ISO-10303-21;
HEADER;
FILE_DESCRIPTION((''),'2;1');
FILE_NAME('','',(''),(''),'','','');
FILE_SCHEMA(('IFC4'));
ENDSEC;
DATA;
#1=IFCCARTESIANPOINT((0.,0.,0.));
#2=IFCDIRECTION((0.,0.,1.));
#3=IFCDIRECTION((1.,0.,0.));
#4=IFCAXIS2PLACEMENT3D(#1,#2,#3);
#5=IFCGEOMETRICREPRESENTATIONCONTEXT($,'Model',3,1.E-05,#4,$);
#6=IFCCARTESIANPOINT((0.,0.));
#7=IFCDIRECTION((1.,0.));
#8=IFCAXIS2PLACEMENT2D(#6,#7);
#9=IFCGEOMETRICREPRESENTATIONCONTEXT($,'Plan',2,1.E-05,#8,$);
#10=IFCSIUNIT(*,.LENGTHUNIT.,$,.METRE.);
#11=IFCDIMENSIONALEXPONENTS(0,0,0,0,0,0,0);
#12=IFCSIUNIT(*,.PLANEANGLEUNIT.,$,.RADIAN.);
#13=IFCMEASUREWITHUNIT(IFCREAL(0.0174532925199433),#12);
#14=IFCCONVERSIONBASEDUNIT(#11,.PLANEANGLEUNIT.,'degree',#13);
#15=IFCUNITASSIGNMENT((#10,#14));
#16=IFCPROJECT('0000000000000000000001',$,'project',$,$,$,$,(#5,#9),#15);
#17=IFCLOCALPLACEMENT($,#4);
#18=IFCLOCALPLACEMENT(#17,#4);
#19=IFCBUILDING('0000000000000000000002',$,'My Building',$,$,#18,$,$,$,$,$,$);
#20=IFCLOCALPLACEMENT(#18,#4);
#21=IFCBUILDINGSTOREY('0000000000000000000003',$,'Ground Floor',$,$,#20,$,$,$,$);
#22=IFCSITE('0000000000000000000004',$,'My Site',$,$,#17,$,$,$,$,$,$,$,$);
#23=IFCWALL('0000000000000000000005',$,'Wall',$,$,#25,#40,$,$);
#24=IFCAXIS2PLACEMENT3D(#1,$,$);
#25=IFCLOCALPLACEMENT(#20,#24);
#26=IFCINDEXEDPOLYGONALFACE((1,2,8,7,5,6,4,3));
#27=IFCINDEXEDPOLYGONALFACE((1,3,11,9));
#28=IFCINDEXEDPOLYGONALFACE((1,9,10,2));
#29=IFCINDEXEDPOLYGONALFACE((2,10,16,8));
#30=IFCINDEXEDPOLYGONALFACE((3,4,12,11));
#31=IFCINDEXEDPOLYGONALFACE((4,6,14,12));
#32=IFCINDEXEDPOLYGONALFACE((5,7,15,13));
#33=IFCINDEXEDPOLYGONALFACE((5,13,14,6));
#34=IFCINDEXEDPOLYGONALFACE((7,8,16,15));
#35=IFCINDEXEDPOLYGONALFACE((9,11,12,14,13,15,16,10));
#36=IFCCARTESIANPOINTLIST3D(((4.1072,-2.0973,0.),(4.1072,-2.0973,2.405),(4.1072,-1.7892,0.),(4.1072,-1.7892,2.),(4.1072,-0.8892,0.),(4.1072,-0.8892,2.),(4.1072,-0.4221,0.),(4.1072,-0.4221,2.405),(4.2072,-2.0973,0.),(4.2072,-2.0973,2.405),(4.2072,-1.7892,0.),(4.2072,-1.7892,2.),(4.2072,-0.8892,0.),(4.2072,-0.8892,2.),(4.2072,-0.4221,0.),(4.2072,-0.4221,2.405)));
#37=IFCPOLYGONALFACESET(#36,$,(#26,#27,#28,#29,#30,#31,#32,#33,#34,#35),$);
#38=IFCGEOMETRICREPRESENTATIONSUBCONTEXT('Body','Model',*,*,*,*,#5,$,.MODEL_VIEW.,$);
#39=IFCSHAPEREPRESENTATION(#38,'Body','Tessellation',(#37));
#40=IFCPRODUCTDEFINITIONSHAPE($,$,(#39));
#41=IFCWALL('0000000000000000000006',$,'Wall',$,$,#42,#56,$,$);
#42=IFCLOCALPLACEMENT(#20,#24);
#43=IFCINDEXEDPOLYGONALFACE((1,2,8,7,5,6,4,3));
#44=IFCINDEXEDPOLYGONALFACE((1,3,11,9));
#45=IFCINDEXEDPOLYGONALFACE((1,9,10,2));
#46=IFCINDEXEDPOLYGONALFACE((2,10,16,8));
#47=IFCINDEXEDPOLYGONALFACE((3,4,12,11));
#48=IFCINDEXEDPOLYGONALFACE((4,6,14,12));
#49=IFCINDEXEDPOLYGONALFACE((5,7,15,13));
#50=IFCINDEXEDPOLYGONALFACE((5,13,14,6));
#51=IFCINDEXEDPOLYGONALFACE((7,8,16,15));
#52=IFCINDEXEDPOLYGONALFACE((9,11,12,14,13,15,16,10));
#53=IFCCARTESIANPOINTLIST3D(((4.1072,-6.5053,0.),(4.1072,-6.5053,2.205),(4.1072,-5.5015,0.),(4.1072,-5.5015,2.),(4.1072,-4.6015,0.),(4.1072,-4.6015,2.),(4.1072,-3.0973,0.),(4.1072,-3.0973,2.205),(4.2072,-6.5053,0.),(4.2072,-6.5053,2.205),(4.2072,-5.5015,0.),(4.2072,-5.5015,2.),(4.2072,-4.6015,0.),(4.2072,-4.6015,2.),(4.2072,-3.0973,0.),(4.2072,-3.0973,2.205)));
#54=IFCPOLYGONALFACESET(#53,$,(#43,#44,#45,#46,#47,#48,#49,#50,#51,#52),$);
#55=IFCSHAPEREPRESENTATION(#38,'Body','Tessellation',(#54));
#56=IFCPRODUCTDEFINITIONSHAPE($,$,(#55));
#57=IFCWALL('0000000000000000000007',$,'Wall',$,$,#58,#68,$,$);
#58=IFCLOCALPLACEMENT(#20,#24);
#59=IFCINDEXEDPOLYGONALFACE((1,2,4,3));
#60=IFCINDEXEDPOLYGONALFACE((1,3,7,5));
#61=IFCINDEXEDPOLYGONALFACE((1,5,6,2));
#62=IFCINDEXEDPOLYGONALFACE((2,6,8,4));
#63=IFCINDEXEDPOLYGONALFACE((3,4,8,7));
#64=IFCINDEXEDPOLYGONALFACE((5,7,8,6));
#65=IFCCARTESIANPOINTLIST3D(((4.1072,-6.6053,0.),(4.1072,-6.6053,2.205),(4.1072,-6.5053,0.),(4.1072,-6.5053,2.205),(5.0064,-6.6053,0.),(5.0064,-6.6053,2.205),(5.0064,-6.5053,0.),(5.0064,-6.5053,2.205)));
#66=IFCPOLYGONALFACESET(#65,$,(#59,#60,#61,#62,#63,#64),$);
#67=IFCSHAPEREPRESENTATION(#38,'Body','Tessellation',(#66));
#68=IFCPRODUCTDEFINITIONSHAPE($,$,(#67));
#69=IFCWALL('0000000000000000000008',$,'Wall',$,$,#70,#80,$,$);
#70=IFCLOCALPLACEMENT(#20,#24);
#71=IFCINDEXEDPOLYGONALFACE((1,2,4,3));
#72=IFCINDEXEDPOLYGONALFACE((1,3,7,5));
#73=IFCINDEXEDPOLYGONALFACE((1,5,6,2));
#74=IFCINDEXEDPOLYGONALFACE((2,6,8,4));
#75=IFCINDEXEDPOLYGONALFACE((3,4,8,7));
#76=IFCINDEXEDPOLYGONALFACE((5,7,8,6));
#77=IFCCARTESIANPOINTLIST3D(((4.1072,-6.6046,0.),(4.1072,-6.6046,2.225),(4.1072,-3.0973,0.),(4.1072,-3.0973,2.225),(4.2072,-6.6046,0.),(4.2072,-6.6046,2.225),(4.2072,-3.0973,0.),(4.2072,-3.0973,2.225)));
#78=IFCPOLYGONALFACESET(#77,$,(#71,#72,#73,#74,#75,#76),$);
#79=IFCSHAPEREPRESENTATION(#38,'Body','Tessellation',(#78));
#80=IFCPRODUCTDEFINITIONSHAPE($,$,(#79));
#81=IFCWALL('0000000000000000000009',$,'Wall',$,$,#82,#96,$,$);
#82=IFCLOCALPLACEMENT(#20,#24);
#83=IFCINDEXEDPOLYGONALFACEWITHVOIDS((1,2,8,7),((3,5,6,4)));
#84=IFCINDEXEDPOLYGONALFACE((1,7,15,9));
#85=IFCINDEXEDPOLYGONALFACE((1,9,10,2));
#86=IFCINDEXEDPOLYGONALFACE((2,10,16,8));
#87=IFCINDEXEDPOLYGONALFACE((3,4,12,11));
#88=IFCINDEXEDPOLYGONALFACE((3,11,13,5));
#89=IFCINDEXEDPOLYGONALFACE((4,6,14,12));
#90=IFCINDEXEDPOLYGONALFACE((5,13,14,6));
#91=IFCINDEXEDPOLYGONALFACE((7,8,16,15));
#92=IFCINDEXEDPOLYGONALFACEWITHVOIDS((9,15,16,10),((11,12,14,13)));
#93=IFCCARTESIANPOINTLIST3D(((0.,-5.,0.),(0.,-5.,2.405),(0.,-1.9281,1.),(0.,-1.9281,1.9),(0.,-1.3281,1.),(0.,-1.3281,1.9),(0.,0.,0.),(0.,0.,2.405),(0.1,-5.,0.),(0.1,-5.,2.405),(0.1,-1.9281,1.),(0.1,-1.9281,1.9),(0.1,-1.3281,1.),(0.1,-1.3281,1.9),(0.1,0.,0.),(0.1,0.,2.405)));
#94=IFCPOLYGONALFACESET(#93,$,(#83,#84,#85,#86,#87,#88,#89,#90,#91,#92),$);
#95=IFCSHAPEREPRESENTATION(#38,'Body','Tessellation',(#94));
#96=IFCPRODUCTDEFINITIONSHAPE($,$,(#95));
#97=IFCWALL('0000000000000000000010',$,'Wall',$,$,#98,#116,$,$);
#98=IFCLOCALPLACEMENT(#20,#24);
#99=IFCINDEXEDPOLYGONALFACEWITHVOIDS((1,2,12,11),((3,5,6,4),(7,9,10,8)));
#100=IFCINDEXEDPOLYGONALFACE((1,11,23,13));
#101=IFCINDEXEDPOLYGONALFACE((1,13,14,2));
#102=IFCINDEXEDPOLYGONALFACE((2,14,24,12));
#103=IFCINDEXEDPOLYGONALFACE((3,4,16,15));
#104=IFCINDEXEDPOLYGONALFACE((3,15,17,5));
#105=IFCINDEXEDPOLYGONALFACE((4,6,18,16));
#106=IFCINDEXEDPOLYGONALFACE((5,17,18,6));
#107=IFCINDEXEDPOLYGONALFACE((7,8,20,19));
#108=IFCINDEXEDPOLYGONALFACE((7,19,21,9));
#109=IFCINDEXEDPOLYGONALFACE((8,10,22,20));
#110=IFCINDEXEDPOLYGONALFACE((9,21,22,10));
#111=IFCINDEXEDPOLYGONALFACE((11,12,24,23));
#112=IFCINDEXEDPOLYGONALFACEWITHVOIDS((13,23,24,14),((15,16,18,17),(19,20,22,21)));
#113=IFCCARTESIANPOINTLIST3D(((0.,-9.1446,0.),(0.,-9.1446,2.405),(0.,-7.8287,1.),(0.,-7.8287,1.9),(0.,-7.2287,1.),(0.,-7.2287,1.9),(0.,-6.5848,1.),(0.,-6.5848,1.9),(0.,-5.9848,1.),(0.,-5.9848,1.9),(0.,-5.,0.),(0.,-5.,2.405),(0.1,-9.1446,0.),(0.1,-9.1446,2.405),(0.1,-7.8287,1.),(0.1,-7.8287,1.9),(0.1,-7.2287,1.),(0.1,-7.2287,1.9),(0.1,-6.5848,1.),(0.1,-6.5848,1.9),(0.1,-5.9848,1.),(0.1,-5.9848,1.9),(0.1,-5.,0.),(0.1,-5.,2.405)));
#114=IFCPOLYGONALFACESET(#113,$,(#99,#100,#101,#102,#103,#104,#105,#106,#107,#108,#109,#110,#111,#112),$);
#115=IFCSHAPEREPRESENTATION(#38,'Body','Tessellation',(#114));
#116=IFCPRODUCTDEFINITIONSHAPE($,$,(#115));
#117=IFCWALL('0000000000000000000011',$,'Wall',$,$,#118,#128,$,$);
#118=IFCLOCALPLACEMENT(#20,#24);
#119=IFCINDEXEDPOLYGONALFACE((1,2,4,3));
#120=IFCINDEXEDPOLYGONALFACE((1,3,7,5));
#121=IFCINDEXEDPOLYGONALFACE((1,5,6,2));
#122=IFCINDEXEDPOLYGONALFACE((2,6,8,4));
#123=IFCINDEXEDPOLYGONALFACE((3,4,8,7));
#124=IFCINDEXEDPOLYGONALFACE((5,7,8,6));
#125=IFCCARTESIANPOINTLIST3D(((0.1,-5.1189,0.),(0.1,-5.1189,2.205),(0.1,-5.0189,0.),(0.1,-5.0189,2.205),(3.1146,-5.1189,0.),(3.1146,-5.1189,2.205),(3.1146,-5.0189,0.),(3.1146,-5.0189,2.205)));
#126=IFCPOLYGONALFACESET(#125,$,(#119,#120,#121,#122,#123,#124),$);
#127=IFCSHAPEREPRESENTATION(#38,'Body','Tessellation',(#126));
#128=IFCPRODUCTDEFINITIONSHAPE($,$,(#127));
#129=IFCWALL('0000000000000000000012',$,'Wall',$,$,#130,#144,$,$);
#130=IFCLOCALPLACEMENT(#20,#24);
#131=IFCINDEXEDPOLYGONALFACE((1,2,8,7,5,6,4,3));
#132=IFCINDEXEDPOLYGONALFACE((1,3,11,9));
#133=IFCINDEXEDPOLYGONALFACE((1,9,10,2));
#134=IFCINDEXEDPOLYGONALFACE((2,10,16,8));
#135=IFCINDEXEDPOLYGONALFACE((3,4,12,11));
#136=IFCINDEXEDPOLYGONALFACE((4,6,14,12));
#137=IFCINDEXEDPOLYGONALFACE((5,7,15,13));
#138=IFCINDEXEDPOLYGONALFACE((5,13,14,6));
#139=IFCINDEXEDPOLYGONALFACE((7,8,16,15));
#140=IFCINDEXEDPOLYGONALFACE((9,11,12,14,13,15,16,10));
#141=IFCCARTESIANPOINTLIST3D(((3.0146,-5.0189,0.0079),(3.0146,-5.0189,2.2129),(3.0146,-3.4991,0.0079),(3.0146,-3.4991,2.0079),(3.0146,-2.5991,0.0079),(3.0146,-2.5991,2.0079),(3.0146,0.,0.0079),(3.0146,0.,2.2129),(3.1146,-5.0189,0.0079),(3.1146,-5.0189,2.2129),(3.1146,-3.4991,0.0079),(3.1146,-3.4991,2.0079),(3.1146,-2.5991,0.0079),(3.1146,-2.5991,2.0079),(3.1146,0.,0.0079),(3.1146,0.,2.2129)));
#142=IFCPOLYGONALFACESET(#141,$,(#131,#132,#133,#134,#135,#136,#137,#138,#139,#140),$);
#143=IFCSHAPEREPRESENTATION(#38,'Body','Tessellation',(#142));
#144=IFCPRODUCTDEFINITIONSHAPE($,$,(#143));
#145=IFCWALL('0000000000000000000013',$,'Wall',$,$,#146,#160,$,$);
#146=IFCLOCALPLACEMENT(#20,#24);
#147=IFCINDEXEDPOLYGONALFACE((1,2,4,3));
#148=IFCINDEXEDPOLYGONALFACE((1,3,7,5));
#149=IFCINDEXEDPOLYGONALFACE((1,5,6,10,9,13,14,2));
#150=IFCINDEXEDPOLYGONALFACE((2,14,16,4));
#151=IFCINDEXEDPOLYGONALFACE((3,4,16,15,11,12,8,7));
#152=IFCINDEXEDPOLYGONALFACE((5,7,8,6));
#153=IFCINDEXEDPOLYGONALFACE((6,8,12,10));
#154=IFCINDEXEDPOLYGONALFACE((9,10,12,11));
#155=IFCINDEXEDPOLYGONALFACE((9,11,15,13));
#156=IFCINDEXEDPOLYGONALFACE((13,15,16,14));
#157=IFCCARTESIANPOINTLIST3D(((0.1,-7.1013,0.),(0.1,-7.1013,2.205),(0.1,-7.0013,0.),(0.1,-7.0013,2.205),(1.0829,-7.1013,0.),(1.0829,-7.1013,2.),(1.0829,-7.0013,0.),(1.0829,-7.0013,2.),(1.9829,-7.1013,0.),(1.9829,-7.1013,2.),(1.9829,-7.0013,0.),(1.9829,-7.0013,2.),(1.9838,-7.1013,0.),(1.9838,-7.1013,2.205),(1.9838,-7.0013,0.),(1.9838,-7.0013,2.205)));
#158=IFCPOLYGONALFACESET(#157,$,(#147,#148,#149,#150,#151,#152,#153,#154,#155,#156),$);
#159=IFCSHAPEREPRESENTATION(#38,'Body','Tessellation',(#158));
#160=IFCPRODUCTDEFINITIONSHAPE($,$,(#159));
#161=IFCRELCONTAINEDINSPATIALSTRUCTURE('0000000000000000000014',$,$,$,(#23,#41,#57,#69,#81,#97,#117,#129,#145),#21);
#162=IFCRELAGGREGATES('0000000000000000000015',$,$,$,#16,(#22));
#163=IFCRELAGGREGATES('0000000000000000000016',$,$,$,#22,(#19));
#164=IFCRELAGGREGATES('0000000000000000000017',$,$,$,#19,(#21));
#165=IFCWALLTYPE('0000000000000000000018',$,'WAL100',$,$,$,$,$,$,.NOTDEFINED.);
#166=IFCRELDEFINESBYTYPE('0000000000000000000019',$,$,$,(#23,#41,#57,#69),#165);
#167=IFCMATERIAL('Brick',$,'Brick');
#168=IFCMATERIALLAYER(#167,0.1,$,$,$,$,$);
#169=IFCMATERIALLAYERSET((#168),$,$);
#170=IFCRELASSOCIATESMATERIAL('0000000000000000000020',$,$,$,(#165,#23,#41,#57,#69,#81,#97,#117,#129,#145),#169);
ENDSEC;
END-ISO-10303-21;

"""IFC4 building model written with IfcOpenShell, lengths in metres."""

from ifc_helpers import new_model, entity, si_unit, converted_unit, frame, origin_with_axes, origin_2d_with_axis, place, context, subcontext, project, spatial, line, indexed_curve, outline, extrude, source, transform, mapped, material, layer, layer_set, layer_usage, type_object, element, save


model = new_model("IFC4")

# Units and contexts
model_context = context("Model", 3, precision=1e-05, world=origin_with_axes())
plan_context = context("Plan", 2, precision=1e-05, world=origin_2d_with_axis())
body_context = subcontext(model_context, "Body", "Model", "MODEL_VIEW")
ifc_project = project(units=[si_unit("LENGTHUNIT", "METRE"), converted_unit("PLANEANGLEUNIT", "degree", entity("IfcReal", 0.0174532925199433), si_unit("PLANEANGLEUNIT", "RADIAN"), dimensions=[0, 0, 0, 0, 0, 0, 0])], contexts=[model_context, plan_context])

# Site, building, storey
site_placement = place(None, origin_with_axes())
site = spatial("IfcSite", under=ifc_project, at=site_placement, Name="My Site")
building_placement = place(site_placement, origin_with_axes())
building = spatial("IfcBuilding", under=site, at=building_placement, Name="My Building")
storey_placement = place(building_placement, origin_with_axes())
storey = spatial("IfcBuildingStorey", under=building, at=storey_placement, Name="Ground Floor")

# Shared definitions
ifc_material_1 = material(Name="Brick", Category="Brick")
ifc_layer_1 = layer(ifc_material_1, 0.1)
ifc_layer_set_1 = layer_set([ifc_layer_1])
wall_type = type_object("IfcWallType", Name="WAL100", PredefinedType="NOTDEFINED", material=ifc_layer_set_1)

# Shared definitions
shared_shape_1 = source(origin_with_axes(), body_context, "Body", "SweptSolid", [
    extrude(outline(indexed_curve([(0.0, 0.0), (0.9, 0.0), (0.9, 2.0), (0.0, 2.0)], segments=[line(1, 2, 3, 4, 1)])), frame((0.0, -0.1, 0.0), z_axis=(0.0, -1.0, 0.0), x_axis=(1.0, 0.0, 0.0)), (0.0, 0.0, -1.0), 0.3),
])

# Walls, openings
ifc_layer_usage_1 = layer_usage(ifc_layer_set_1, "AXIS2", "POSITIVE", 0.0)
wall_1_placement = place(storey_placement, frame((4.1072, -0.4221, 0.0), z_axis=(0.0, 0.0, 1.0), x_axis=(-0.000001, -1.0, 0.0)))
wall_1 = element("IfcWall", 1, at=wall_1_placement, inside=storey, type_object=wall_type, material=ifc_layer_usage_1, Name="Wall", context=body_context, shape_type="SweptSolid", body=[
    extrude(outline(indexed_curve([(0.0, 0.0), (0.0, 0.1), (1.6752, 0.1), (1.6752, 0.0), (0.0, 0.0)], self_intersect=False)), origin_with_axes(), (0.0, 0.0, 1.0), 2.405),
])
opening_1_placement = place(wall_1_placement, frame((0.4671, 0.0, 0.0), z_axis=(0.0, 0.0, 1.0), x_axis=(1.0, 0.0, 0.0)))
element("IfcOpeningElement", 2, at=opening_1_placement, cuts=wall_1, PredefinedType="OPENING", context=body_context, shape_type="MappedRepresentation", body=[
    mapped(shared_shape_1, transform((0.0, 0.0, 0.0), x_axis=(1.0, 0.0, 0.0), y_axis=(0.0, 1.0, 0.0), z_axis=(0.0, 0.0, 1.0), scale=1.0)),
])
ifc_layer_usage_2 = layer_usage(ifc_layer_set_1, "AXIS2", "POSITIVE", 0.0)
wall_2_placement = place(storey_placement, frame((4.1072, -3.0973, 0.0), z_axis=(0.0, 0.0, 1.0), x_axis=(-0.000001, -1.0, 0.0)))
wall_2 = element("IfcWall", 3, at=wall_2_placement, inside=storey, type_object=wall_type, material=ifc_layer_usage_2, Name="Wall", context=body_context, shape_type="SweptSolid", body=[
    extrude(outline(indexed_curve([(0.0, 0.0), (0.0, 0.1), (3.408, 0.1), (3.408, 0.0), (0.0, 0.0)], self_intersect=False)), origin_with_axes(), (0.0, 0.0, 1.0), 2.205),
])
opening_2_placement = place(wall_2_placement, frame((2.4042, 0.1, 0.0), z_axis=(0.0, 0.0, 1.0), x_axis=(-1.0, 0.0, 0.0)))
element("IfcOpeningElement", 4, at=opening_2_placement, cuts=wall_2, PredefinedType="OPENING", context=body_context, shape_type="MappedRepresentation", body=[
    mapped(shared_shape_1, transform((0.0, 0.0, 0.0), x_axis=(1.0, 0.0, 0.0), y_axis=(0.0, 1.0, 0.0), z_axis=(0.0, 0.0, 1.0), scale=1.0)),
])

# Walls
ifc_layer_usage_3 = layer_usage(ifc_layer_set_1, "AXIS2", "POSITIVE", 0.0)
wall_3_placement = place(storey_placement, frame((5.0064, -6.5053, 0.0), z_axis=(0.0, 0.0, 1.0), x_axis=(-1.0, 0.000001, 0.0)))
element("IfcWall", 5, at=wall_3_placement, inside=storey, type_object=wall_type, material=ifc_layer_usage_3, Name="Wall", context=body_context, shape_type="SweptSolid", body=[
    extrude(outline(indexed_curve([(0.0, 0.0), (0.0, 0.1), (0.8992, 0.1), (0.8992, 0.0), (0.0, 0.0)], self_intersect=False)), origin_with_axes(), (0.0, 0.0, 1.0), 2.205),
])
ifc_layer_usage_4 = layer_usage(ifc_layer_set_1, "AXIS2", "POSITIVE", 0.0)
wall_4_placement = place(storey_placement, frame((4.1072, -3.0973, 0.0), z_axis=(0.0, 0.0, 1.0), x_axis=(-0.000001, -1.0, 0.0)))
element("IfcWall", 6, at=wall_4_placement, inside=storey, type_object=wall_type, material=ifc_layer_usage_4, Name="Wall", context=body_context, shape_type="SweptSolid", body=[
    extrude(outline(indexed_curve([(0.0, 0.0), (0.0, 0.1), (3.5073, 0.1), (3.5073, 0.0), (0.0, 0.0)], self_intersect=False)), origin_with_axes(), (0.0, 0.0, 1.0), 2.225),
])

# Wall, opening
ifc_layer_usage_5 = layer_usage(ifc_layer_set_1, "AXIS2", "POSITIVE", 0.0)
wall_5_placement = place(storey_placement, frame((0.0, 0.0, 0.0), z_axis=(0.0, 0.0, 1.0), x_axis=(-0.000001, -1.0, 0.0)))
wall_5 = element("IfcWall", 7, at=wall_5_placement, inside=storey, material=ifc_layer_usage_5, Name="Wall", context=body_context, shape_type="SweptSolid", body=[
    extrude(outline(indexed_curve([(0.0, 0.0), (0.0, 0.1), (5.0, 0.1), (5.0, 0.0), (0.0, 0.0)], self_intersect=False)), origin_with_axes(), (0.0, 0.0, 1.0), 2.405),
])
shared_shape_2 = source(origin_with_axes(), body_context, "Body", "SweptSolid", [
    extrude(outline(indexed_curve([(0.0, 0.0), (0.6, 0.0), (0.6, 0.9), (0.0, 0.9)], segments=[line(1, 2, 3, 4, 1)])), frame((0.0, -0.1, 0.0), z_axis=(0.0, -1.0, 0.0), x_axis=(1.0, 0.0, 0.0)), (0.0, 0.0, -1.0), 0.3),
])
opening_3_placement = place(wall_5_placement, frame((1.3281, 0.0, 1.0), z_axis=(0.0, 0.0, 1.0), x_axis=(1.0, 0.0, 0.0)))
element("IfcOpeningElement", 8, at=opening_3_placement, cuts=wall_5, PredefinedType="OPENING", context=body_context, shape_type="MappedRepresentation", body=[
    mapped(shared_shape_2, transform((0.0, 0.0, 0.0), x_axis=(1.0, 0.0, 0.0), y_axis=(0.0, 1.0, 0.0), z_axis=(0.0, 0.0, 1.0), scale=1.0)),
])

# Wall, openings
ifc_layer_usage_6 = layer_usage(ifc_layer_set_1, "AXIS2", "POSITIVE", 0.0)
wall_6_placement = place(storey_placement, frame((0.0, -5.0, 0.0), z_axis=(0.0, 0.0, 1.0), x_axis=(-0.000001, -1.0, 0.0)))
wall_6 = element("IfcWall", 9, at=wall_6_placement, inside=storey, material=ifc_layer_usage_6, Name="Wall", context=body_context, shape_type="SweptSolid", body=[
    extrude(outline(indexed_curve([(0.0, 0.0), (0.0, 0.1), (4.1446, 0.1), (4.1446, 0.0), (0.0, 0.0)], self_intersect=False)), origin_with_axes(), (0.0, 0.0, 1.0), 2.405),
])
opening_4_placement = place(wall_6_placement, frame((2.2287, 0.0, 1.0), z_axis=(0.0, 0.0, 1.0), x_axis=(1.0, 0.0, 0.0)))
element("IfcOpeningElement", 10, at=opening_4_placement, cuts=wall_6, PredefinedType="OPENING", context=body_context, shape_type="MappedRepresentation", body=[
    mapped(shared_shape_2, transform((0.0, 0.0, 0.0), x_axis=(1.0, 0.0, 0.0), y_axis=(0.0, 1.0, 0.0), z_axis=(0.0, 0.0, 1.0), scale=1.0)),
])
opening_5_placement = place(wall_6_placement, frame((0.9848, 0.0, 1.0), z_axis=(0.0, 0.0, 1.0), x_axis=(1.0, 0.0, 0.0)))
element("IfcOpeningElement", 11, at=opening_5_placement, cuts=wall_6, PredefinedType="OPENING", context=body_context, shape_type="MappedRepresentation", body=[
    mapped(shared_shape_2, transform((0.0, 0.0, 0.0), x_axis=(1.0, 0.0, 0.0), y_axis=(0.0, 1.0, 0.0), z_axis=(0.0, 0.0, 1.0), scale=1.0)),
])

# Wall
ifc_layer_usage_7 = layer_usage(ifc_layer_set_1, "AXIS2", "POSITIVE", 0.0)
wall_7_placement = place(storey_placement, frame((3.1146, -5.0189, 0.0), z_axis=(0.0, 0.0, 1.0), x_axis=(-1.0, 0.0, 0.0)))
element("IfcWall", 12, at=wall_7_placement, inside=storey, material=ifc_layer_usage_7, Name="Wall", context=body_context, shape_type="SweptSolid", body=[
    extrude(outline(indexed_curve([(0.0, 0.0), (0.0, 0.1), (3.0146, 0.1), (3.0146, 0.0), (0.0, 0.0)], self_intersect=False)), origin_with_axes(), (0.0, 0.0, 1.0), 2.205),
])

# Walls, openings
ifc_layer_usage_8 = layer_usage(ifc_layer_set_1, "AXIS2", "POSITIVE", 0.0)
wall_8_placement = place(storey_placement, frame((3.1146, -5.0189, 0.0079), z_axis=(0.0, 0.0, 1.0), x_axis=(0.000001, 1.0, 0.0)))
wall_8 = element("IfcWall", 13, at=wall_8_placement, inside=storey, material=ifc_layer_usage_8, Name="Wall", context=body_context, shape_type="SweptSolid", body=[
    extrude(outline(indexed_curve([(0.0, 0.0), (0.0, 0.1), (5.0189, 0.1), (5.0189, 0.0), (0.0, 0.0)], self_intersect=False)), origin_with_axes(), (0.0, 0.0, 1.0), 2.205),
])
opening_6_placement = place(wall_8_placement, frame((2.4198, 0.1, 0.0), z_axis=(0.0, 0.0, 1.0), x_axis=(-1.0, 0.0, 0.0)))
element("IfcOpeningElement", 14, at=opening_6_placement, cuts=wall_8, PredefinedType="OPENING", context=body_context, shape_type="MappedRepresentation", body=[
    mapped(shared_shape_1, transform((0.0, 0.0, 0.0), x_axis=(1.0, 0.0, 0.0), y_axis=(0.0, 1.0, 0.0), z_axis=(0.0, 0.0, 1.0), scale=1.0)),
])
ifc_layer_usage_9 = layer_usage(ifc_layer_set_1, "AXIS2", "POSITIVE", 0.0)
wall_9_placement = place(storey_placement, frame((0.1, -7.1013, 0.0), z_axis=(0.0, 0.0, 1.0), x_axis=(1.0, 0.0, 0.0)))
wall_9 = element("IfcWall", 15, at=wall_9_placement, inside=storey, material=ifc_layer_usage_9, Name="Wall", context=body_context, shape_type="SweptSolid", body=[
    extrude(outline(indexed_curve([(0.0, 0.0), (0.0, 0.1), (1.8838, 0.1), (1.8838, 0.0), (0.0, 0.0)], self_intersect=False)), origin_with_axes(), (0.0, 0.0, 1.0), 2.205),
])
opening_7_placement = place(wall_9_placement, frame((1.8829, 0.1, 0.0), z_axis=(0.0, 0.0, 1.0), x_axis=(-1.0, 0.0, 0.0)))
element("IfcOpeningElement", 16, at=opening_7_placement, cuts=wall_9, PredefinedType="OPENING", context=body_context, shape_type="MappedRepresentation", body=[
    mapped(shared_shape_1, transform((0.0, 0.0, 0.0), x_axis=(1.0, 0.0, 0.0), y_axis=(0.0, 1.0, 0.0), z_axis=(0.0, 0.0, 1.0), scale=1.0)),
])

save(model, "model.ifc")
